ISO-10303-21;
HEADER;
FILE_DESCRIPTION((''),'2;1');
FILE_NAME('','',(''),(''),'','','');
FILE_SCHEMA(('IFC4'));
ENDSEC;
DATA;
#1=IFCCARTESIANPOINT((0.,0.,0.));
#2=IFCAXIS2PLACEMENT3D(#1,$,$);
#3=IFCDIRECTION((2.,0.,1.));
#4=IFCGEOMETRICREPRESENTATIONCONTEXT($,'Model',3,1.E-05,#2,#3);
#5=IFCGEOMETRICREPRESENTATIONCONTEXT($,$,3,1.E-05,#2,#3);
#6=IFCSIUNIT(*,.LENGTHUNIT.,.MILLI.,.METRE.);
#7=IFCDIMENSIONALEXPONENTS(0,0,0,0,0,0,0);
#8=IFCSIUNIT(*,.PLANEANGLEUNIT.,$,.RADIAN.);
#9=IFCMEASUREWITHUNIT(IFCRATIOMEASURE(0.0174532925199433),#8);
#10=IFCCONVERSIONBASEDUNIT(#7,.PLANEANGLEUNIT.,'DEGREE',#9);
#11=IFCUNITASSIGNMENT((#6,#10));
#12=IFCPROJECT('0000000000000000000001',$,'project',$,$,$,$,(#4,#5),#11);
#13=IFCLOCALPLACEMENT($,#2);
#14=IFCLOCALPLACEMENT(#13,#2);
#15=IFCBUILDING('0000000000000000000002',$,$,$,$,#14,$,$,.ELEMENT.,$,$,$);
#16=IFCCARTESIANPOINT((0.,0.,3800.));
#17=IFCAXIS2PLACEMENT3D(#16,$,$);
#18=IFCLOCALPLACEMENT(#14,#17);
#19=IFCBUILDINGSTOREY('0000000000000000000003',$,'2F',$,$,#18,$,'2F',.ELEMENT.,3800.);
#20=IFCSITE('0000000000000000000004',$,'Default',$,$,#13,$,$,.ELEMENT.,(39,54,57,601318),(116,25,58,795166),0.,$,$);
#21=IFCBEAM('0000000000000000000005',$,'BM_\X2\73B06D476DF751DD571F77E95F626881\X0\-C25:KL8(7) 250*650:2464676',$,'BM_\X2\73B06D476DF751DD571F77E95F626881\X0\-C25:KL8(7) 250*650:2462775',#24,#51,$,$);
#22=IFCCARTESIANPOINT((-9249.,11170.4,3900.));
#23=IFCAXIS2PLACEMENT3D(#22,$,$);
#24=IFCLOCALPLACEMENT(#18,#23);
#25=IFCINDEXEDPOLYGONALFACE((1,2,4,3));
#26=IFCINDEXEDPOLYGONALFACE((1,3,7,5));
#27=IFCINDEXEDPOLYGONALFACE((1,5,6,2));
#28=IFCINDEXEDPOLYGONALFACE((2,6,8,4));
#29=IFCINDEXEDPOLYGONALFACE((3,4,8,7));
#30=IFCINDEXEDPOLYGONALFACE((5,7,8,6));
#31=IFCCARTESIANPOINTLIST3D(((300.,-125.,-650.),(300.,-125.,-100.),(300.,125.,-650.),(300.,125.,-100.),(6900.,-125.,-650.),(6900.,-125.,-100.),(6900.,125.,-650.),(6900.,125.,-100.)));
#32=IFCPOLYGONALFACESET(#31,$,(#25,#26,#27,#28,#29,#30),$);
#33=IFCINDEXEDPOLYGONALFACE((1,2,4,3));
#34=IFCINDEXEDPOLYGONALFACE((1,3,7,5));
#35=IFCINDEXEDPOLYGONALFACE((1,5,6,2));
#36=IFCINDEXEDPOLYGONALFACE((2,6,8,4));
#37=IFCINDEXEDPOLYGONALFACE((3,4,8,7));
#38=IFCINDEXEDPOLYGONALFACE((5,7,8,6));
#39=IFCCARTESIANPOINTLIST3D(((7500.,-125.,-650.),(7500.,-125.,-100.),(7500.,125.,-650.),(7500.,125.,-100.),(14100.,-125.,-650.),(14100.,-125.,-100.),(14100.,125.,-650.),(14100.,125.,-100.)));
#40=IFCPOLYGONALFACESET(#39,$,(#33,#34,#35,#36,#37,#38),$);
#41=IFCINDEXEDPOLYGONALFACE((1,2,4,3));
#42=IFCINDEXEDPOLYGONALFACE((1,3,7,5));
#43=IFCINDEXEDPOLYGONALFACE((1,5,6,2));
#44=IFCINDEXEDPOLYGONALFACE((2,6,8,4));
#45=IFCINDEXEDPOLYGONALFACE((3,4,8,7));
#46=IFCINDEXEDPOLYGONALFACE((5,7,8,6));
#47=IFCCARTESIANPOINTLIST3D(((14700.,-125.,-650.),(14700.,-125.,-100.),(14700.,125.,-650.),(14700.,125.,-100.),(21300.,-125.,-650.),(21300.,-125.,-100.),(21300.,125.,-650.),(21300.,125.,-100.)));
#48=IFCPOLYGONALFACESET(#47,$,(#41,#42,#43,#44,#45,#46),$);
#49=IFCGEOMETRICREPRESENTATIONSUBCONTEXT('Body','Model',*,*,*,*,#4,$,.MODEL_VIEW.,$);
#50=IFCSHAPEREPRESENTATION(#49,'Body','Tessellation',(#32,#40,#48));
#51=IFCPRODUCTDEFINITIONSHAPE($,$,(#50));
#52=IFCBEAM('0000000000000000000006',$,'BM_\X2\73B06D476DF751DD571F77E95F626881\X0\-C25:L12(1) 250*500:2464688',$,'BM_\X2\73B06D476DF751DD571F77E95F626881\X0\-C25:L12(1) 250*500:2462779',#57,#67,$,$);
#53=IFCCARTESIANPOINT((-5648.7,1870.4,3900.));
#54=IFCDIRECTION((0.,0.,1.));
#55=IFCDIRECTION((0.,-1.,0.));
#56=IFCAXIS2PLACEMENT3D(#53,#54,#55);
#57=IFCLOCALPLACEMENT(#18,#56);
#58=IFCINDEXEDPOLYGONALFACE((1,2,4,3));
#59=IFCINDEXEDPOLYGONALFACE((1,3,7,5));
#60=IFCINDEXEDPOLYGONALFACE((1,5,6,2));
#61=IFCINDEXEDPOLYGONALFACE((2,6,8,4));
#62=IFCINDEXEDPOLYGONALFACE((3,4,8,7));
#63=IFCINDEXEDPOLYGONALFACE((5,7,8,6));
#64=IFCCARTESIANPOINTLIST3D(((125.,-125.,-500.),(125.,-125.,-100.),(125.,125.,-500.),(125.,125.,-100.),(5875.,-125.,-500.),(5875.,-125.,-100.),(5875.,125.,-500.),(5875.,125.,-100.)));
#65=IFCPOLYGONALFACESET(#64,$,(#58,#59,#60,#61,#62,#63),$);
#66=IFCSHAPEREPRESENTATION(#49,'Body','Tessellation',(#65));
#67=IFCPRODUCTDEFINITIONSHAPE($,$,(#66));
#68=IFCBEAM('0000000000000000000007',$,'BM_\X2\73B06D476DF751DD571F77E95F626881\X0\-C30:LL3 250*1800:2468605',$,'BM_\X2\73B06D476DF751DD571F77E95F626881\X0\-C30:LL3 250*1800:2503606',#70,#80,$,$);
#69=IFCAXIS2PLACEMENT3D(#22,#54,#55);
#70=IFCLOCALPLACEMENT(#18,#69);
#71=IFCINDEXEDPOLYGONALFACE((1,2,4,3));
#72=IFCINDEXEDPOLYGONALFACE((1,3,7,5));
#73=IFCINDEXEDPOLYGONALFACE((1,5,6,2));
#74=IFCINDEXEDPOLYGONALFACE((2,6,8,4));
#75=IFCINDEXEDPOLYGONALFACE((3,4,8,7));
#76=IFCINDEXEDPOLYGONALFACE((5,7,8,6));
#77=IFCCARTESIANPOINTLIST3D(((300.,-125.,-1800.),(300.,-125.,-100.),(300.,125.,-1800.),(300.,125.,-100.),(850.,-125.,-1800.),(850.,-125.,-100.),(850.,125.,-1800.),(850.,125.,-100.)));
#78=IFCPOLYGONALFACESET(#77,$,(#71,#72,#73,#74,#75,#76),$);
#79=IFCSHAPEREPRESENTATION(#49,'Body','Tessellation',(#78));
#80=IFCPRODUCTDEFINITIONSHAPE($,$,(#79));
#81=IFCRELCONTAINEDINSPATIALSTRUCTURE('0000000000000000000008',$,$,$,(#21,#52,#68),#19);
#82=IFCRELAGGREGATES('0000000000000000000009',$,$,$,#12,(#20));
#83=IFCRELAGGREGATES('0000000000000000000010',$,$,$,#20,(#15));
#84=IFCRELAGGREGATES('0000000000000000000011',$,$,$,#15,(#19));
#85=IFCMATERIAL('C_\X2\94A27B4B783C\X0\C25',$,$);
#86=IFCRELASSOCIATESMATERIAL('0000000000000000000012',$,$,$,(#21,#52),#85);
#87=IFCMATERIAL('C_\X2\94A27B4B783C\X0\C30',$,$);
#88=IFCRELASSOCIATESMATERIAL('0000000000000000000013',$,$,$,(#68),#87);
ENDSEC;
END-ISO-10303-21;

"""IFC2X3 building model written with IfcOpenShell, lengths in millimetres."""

from ifc_helpers import new_model, entity, si_unit, converted_unit, direction, frame, frame_2d, origin, place, context, subcontext, project, spatial, rectangle, extrude, material, element, save


model = new_model("IFC2X3")

# Units and contexts
model_context = context("Model", 3, precision=1e-05, world=origin(), true_north=direction((2.0, 0.0, 1.0)))
context_of_model = context(None, 3, precision=1e-05, world=origin(), true_north=direction((2.0, 0.0, 1.0)))
body_context = subcontext(model_context, "Body", "Model", "MODEL_VIEW")
ifc_project = project(units=[si_unit("LENGTHUNIT", "METRE", prefix="MILLI"), converted_unit("PLANEANGLEUNIT", "DEGREE", entity("IfcRatioMeasure", 0.0174532925199433), si_unit("PLANEANGLEUNIT", "RADIAN"), dimensions=[0, 0, 0, 0, 0, 0, 0])], contexts=[model_context, context_of_model])

# Site, building, storey
site_placement = place(None, origin())
site = spatial("IfcSite", under=ifc_project, at=site_placement, Name="Default", CompositionType="ELEMENT", RefLatitude=(39, 54, 57, 601318), RefLongitude=(116, 25, 58, 795166), RefElevation=0.0)
building_placement = place(site_placement, origin())
building = spatial("IfcBuilding", under=site, at=building_placement, CompositionType="ELEMENT")
storey_placement = place(building_placement, frame((0.0, 0.0, 3800.0)))
storey = spatial("IfcBuildingStorey", under=building, at=storey_placement, Name="2F", LongName="2F", CompositionType="ELEMENT", Elevation=3800.0)

# Shared definitions
ifc_material_1 = material(Name="C_钢筋砼C25")

# Beams
beam_1_placement = place(storey_placement, frame((-9249.0, 11170.4, 3900.0)))
element("IfcBeam", 1, at=beam_1_placement, inside=storey, material=ifc_material_1, Name="BM_现浇混凝土矩形梁-C25:KL8(7) 250*650:2464676", ObjectType="BM_现浇混凝土矩形梁-C25:KL8(7) 250*650:2462775", context=body_context, shape_type="SweptSolid", body=[
    extrude(rectangle(XDim=550.0, YDim=250.0, at=frame_2d((0.0, 0.0), x_axis=(1.0, 0.0))), frame((300.0, 0.0, -375.0), z_axis=(1.0, 0.0, 0.0), x_axis=(0.0, 0.0, 1.0)), (0.0, 0.0, 1.0), 6600.0),
    extrude(rectangle(XDim=550.0, YDim=250.0, at=frame_2d((0.0, 0.0), x_axis=(1.0, 0.0))), frame((7500.0, 0.0, -375.0), z_axis=(1.0, 0.0, 0.0), x_axis=(0.0, 0.0, 1.0)), (0.0, 0.0, 1.0), 6600.0),
    extrude(rectangle(XDim=550.0, YDim=250.0, at=frame_2d((-45.0, -25.0), x_axis=(1.0, 0.0))), frame((14700.0, -25.0, -330.0), z_axis=(1.0, 0.0, 0.0), x_axis=(0.0, 0.0, 1.0)), (0.0, 0.0, 1.0), 6600.0),
])
beam_2_placement = place(storey_placement, frame((-5648.7, 1870.4, 3900.0), z_axis=(0.0, 0.0, 1.0), x_axis=(0.0, -1.0, 0.0)))
element("IfcBeam", 2, at=beam_2_placement, inside=storey, material=ifc_material_1, Name="BM_现浇混凝土矩形梁-C25:L12(1) 250*500:2464688", ObjectType="BM_现浇混凝土矩形梁-C25:L12(1) 250*500:2462779", context=body_context, shape_type="SweptSolid", body=[
    extrude(rectangle(XDim=400.0, YDim=250.0, at=frame_2d((0.0, 0.0), x_axis=(1.0, 0.0))), frame((125.0, 0.0, -300.0), z_axis=(1.0, 0.0, 0.0), x_axis=(0.0, 0.0, -1.0)), (0.0, 0.0, 1.0), 5750.0),
])
ifc_material_2 = material(Name="C_钢筋砼C30")
beam_3_placement = place(storey_placement, frame((-9249.0, 11170.4, 3900.0), z_axis=(0.0, 0.0, 1.0), x_axis=(0.0, -1.0, 0.0)))
element("IfcBeam", 3, at=beam_3_placement, inside=storey, material=ifc_material_2, Name="BM_现浇混凝土矩形梁-C30:LL3 250*1800:2468605", ObjectType="BM_现浇混凝土矩形梁-C30:LL3 250*1800:2503606", context=body_context, shape_type="SweptSolid", body=[
    extrude(rectangle(XDim=1700.0, YDim=250.0, at=frame_2d((0.0, 0.0), x_axis=(1.0, 0.0))), frame((300.0, 0.0, -950.0), z_axis=(1.0, 0.0, 0.0), x_axis=(0.0, 0.0, -1.0)), (0.0, 0.0, 1.0), 550.0),
])

save(model, "model.ifc")
